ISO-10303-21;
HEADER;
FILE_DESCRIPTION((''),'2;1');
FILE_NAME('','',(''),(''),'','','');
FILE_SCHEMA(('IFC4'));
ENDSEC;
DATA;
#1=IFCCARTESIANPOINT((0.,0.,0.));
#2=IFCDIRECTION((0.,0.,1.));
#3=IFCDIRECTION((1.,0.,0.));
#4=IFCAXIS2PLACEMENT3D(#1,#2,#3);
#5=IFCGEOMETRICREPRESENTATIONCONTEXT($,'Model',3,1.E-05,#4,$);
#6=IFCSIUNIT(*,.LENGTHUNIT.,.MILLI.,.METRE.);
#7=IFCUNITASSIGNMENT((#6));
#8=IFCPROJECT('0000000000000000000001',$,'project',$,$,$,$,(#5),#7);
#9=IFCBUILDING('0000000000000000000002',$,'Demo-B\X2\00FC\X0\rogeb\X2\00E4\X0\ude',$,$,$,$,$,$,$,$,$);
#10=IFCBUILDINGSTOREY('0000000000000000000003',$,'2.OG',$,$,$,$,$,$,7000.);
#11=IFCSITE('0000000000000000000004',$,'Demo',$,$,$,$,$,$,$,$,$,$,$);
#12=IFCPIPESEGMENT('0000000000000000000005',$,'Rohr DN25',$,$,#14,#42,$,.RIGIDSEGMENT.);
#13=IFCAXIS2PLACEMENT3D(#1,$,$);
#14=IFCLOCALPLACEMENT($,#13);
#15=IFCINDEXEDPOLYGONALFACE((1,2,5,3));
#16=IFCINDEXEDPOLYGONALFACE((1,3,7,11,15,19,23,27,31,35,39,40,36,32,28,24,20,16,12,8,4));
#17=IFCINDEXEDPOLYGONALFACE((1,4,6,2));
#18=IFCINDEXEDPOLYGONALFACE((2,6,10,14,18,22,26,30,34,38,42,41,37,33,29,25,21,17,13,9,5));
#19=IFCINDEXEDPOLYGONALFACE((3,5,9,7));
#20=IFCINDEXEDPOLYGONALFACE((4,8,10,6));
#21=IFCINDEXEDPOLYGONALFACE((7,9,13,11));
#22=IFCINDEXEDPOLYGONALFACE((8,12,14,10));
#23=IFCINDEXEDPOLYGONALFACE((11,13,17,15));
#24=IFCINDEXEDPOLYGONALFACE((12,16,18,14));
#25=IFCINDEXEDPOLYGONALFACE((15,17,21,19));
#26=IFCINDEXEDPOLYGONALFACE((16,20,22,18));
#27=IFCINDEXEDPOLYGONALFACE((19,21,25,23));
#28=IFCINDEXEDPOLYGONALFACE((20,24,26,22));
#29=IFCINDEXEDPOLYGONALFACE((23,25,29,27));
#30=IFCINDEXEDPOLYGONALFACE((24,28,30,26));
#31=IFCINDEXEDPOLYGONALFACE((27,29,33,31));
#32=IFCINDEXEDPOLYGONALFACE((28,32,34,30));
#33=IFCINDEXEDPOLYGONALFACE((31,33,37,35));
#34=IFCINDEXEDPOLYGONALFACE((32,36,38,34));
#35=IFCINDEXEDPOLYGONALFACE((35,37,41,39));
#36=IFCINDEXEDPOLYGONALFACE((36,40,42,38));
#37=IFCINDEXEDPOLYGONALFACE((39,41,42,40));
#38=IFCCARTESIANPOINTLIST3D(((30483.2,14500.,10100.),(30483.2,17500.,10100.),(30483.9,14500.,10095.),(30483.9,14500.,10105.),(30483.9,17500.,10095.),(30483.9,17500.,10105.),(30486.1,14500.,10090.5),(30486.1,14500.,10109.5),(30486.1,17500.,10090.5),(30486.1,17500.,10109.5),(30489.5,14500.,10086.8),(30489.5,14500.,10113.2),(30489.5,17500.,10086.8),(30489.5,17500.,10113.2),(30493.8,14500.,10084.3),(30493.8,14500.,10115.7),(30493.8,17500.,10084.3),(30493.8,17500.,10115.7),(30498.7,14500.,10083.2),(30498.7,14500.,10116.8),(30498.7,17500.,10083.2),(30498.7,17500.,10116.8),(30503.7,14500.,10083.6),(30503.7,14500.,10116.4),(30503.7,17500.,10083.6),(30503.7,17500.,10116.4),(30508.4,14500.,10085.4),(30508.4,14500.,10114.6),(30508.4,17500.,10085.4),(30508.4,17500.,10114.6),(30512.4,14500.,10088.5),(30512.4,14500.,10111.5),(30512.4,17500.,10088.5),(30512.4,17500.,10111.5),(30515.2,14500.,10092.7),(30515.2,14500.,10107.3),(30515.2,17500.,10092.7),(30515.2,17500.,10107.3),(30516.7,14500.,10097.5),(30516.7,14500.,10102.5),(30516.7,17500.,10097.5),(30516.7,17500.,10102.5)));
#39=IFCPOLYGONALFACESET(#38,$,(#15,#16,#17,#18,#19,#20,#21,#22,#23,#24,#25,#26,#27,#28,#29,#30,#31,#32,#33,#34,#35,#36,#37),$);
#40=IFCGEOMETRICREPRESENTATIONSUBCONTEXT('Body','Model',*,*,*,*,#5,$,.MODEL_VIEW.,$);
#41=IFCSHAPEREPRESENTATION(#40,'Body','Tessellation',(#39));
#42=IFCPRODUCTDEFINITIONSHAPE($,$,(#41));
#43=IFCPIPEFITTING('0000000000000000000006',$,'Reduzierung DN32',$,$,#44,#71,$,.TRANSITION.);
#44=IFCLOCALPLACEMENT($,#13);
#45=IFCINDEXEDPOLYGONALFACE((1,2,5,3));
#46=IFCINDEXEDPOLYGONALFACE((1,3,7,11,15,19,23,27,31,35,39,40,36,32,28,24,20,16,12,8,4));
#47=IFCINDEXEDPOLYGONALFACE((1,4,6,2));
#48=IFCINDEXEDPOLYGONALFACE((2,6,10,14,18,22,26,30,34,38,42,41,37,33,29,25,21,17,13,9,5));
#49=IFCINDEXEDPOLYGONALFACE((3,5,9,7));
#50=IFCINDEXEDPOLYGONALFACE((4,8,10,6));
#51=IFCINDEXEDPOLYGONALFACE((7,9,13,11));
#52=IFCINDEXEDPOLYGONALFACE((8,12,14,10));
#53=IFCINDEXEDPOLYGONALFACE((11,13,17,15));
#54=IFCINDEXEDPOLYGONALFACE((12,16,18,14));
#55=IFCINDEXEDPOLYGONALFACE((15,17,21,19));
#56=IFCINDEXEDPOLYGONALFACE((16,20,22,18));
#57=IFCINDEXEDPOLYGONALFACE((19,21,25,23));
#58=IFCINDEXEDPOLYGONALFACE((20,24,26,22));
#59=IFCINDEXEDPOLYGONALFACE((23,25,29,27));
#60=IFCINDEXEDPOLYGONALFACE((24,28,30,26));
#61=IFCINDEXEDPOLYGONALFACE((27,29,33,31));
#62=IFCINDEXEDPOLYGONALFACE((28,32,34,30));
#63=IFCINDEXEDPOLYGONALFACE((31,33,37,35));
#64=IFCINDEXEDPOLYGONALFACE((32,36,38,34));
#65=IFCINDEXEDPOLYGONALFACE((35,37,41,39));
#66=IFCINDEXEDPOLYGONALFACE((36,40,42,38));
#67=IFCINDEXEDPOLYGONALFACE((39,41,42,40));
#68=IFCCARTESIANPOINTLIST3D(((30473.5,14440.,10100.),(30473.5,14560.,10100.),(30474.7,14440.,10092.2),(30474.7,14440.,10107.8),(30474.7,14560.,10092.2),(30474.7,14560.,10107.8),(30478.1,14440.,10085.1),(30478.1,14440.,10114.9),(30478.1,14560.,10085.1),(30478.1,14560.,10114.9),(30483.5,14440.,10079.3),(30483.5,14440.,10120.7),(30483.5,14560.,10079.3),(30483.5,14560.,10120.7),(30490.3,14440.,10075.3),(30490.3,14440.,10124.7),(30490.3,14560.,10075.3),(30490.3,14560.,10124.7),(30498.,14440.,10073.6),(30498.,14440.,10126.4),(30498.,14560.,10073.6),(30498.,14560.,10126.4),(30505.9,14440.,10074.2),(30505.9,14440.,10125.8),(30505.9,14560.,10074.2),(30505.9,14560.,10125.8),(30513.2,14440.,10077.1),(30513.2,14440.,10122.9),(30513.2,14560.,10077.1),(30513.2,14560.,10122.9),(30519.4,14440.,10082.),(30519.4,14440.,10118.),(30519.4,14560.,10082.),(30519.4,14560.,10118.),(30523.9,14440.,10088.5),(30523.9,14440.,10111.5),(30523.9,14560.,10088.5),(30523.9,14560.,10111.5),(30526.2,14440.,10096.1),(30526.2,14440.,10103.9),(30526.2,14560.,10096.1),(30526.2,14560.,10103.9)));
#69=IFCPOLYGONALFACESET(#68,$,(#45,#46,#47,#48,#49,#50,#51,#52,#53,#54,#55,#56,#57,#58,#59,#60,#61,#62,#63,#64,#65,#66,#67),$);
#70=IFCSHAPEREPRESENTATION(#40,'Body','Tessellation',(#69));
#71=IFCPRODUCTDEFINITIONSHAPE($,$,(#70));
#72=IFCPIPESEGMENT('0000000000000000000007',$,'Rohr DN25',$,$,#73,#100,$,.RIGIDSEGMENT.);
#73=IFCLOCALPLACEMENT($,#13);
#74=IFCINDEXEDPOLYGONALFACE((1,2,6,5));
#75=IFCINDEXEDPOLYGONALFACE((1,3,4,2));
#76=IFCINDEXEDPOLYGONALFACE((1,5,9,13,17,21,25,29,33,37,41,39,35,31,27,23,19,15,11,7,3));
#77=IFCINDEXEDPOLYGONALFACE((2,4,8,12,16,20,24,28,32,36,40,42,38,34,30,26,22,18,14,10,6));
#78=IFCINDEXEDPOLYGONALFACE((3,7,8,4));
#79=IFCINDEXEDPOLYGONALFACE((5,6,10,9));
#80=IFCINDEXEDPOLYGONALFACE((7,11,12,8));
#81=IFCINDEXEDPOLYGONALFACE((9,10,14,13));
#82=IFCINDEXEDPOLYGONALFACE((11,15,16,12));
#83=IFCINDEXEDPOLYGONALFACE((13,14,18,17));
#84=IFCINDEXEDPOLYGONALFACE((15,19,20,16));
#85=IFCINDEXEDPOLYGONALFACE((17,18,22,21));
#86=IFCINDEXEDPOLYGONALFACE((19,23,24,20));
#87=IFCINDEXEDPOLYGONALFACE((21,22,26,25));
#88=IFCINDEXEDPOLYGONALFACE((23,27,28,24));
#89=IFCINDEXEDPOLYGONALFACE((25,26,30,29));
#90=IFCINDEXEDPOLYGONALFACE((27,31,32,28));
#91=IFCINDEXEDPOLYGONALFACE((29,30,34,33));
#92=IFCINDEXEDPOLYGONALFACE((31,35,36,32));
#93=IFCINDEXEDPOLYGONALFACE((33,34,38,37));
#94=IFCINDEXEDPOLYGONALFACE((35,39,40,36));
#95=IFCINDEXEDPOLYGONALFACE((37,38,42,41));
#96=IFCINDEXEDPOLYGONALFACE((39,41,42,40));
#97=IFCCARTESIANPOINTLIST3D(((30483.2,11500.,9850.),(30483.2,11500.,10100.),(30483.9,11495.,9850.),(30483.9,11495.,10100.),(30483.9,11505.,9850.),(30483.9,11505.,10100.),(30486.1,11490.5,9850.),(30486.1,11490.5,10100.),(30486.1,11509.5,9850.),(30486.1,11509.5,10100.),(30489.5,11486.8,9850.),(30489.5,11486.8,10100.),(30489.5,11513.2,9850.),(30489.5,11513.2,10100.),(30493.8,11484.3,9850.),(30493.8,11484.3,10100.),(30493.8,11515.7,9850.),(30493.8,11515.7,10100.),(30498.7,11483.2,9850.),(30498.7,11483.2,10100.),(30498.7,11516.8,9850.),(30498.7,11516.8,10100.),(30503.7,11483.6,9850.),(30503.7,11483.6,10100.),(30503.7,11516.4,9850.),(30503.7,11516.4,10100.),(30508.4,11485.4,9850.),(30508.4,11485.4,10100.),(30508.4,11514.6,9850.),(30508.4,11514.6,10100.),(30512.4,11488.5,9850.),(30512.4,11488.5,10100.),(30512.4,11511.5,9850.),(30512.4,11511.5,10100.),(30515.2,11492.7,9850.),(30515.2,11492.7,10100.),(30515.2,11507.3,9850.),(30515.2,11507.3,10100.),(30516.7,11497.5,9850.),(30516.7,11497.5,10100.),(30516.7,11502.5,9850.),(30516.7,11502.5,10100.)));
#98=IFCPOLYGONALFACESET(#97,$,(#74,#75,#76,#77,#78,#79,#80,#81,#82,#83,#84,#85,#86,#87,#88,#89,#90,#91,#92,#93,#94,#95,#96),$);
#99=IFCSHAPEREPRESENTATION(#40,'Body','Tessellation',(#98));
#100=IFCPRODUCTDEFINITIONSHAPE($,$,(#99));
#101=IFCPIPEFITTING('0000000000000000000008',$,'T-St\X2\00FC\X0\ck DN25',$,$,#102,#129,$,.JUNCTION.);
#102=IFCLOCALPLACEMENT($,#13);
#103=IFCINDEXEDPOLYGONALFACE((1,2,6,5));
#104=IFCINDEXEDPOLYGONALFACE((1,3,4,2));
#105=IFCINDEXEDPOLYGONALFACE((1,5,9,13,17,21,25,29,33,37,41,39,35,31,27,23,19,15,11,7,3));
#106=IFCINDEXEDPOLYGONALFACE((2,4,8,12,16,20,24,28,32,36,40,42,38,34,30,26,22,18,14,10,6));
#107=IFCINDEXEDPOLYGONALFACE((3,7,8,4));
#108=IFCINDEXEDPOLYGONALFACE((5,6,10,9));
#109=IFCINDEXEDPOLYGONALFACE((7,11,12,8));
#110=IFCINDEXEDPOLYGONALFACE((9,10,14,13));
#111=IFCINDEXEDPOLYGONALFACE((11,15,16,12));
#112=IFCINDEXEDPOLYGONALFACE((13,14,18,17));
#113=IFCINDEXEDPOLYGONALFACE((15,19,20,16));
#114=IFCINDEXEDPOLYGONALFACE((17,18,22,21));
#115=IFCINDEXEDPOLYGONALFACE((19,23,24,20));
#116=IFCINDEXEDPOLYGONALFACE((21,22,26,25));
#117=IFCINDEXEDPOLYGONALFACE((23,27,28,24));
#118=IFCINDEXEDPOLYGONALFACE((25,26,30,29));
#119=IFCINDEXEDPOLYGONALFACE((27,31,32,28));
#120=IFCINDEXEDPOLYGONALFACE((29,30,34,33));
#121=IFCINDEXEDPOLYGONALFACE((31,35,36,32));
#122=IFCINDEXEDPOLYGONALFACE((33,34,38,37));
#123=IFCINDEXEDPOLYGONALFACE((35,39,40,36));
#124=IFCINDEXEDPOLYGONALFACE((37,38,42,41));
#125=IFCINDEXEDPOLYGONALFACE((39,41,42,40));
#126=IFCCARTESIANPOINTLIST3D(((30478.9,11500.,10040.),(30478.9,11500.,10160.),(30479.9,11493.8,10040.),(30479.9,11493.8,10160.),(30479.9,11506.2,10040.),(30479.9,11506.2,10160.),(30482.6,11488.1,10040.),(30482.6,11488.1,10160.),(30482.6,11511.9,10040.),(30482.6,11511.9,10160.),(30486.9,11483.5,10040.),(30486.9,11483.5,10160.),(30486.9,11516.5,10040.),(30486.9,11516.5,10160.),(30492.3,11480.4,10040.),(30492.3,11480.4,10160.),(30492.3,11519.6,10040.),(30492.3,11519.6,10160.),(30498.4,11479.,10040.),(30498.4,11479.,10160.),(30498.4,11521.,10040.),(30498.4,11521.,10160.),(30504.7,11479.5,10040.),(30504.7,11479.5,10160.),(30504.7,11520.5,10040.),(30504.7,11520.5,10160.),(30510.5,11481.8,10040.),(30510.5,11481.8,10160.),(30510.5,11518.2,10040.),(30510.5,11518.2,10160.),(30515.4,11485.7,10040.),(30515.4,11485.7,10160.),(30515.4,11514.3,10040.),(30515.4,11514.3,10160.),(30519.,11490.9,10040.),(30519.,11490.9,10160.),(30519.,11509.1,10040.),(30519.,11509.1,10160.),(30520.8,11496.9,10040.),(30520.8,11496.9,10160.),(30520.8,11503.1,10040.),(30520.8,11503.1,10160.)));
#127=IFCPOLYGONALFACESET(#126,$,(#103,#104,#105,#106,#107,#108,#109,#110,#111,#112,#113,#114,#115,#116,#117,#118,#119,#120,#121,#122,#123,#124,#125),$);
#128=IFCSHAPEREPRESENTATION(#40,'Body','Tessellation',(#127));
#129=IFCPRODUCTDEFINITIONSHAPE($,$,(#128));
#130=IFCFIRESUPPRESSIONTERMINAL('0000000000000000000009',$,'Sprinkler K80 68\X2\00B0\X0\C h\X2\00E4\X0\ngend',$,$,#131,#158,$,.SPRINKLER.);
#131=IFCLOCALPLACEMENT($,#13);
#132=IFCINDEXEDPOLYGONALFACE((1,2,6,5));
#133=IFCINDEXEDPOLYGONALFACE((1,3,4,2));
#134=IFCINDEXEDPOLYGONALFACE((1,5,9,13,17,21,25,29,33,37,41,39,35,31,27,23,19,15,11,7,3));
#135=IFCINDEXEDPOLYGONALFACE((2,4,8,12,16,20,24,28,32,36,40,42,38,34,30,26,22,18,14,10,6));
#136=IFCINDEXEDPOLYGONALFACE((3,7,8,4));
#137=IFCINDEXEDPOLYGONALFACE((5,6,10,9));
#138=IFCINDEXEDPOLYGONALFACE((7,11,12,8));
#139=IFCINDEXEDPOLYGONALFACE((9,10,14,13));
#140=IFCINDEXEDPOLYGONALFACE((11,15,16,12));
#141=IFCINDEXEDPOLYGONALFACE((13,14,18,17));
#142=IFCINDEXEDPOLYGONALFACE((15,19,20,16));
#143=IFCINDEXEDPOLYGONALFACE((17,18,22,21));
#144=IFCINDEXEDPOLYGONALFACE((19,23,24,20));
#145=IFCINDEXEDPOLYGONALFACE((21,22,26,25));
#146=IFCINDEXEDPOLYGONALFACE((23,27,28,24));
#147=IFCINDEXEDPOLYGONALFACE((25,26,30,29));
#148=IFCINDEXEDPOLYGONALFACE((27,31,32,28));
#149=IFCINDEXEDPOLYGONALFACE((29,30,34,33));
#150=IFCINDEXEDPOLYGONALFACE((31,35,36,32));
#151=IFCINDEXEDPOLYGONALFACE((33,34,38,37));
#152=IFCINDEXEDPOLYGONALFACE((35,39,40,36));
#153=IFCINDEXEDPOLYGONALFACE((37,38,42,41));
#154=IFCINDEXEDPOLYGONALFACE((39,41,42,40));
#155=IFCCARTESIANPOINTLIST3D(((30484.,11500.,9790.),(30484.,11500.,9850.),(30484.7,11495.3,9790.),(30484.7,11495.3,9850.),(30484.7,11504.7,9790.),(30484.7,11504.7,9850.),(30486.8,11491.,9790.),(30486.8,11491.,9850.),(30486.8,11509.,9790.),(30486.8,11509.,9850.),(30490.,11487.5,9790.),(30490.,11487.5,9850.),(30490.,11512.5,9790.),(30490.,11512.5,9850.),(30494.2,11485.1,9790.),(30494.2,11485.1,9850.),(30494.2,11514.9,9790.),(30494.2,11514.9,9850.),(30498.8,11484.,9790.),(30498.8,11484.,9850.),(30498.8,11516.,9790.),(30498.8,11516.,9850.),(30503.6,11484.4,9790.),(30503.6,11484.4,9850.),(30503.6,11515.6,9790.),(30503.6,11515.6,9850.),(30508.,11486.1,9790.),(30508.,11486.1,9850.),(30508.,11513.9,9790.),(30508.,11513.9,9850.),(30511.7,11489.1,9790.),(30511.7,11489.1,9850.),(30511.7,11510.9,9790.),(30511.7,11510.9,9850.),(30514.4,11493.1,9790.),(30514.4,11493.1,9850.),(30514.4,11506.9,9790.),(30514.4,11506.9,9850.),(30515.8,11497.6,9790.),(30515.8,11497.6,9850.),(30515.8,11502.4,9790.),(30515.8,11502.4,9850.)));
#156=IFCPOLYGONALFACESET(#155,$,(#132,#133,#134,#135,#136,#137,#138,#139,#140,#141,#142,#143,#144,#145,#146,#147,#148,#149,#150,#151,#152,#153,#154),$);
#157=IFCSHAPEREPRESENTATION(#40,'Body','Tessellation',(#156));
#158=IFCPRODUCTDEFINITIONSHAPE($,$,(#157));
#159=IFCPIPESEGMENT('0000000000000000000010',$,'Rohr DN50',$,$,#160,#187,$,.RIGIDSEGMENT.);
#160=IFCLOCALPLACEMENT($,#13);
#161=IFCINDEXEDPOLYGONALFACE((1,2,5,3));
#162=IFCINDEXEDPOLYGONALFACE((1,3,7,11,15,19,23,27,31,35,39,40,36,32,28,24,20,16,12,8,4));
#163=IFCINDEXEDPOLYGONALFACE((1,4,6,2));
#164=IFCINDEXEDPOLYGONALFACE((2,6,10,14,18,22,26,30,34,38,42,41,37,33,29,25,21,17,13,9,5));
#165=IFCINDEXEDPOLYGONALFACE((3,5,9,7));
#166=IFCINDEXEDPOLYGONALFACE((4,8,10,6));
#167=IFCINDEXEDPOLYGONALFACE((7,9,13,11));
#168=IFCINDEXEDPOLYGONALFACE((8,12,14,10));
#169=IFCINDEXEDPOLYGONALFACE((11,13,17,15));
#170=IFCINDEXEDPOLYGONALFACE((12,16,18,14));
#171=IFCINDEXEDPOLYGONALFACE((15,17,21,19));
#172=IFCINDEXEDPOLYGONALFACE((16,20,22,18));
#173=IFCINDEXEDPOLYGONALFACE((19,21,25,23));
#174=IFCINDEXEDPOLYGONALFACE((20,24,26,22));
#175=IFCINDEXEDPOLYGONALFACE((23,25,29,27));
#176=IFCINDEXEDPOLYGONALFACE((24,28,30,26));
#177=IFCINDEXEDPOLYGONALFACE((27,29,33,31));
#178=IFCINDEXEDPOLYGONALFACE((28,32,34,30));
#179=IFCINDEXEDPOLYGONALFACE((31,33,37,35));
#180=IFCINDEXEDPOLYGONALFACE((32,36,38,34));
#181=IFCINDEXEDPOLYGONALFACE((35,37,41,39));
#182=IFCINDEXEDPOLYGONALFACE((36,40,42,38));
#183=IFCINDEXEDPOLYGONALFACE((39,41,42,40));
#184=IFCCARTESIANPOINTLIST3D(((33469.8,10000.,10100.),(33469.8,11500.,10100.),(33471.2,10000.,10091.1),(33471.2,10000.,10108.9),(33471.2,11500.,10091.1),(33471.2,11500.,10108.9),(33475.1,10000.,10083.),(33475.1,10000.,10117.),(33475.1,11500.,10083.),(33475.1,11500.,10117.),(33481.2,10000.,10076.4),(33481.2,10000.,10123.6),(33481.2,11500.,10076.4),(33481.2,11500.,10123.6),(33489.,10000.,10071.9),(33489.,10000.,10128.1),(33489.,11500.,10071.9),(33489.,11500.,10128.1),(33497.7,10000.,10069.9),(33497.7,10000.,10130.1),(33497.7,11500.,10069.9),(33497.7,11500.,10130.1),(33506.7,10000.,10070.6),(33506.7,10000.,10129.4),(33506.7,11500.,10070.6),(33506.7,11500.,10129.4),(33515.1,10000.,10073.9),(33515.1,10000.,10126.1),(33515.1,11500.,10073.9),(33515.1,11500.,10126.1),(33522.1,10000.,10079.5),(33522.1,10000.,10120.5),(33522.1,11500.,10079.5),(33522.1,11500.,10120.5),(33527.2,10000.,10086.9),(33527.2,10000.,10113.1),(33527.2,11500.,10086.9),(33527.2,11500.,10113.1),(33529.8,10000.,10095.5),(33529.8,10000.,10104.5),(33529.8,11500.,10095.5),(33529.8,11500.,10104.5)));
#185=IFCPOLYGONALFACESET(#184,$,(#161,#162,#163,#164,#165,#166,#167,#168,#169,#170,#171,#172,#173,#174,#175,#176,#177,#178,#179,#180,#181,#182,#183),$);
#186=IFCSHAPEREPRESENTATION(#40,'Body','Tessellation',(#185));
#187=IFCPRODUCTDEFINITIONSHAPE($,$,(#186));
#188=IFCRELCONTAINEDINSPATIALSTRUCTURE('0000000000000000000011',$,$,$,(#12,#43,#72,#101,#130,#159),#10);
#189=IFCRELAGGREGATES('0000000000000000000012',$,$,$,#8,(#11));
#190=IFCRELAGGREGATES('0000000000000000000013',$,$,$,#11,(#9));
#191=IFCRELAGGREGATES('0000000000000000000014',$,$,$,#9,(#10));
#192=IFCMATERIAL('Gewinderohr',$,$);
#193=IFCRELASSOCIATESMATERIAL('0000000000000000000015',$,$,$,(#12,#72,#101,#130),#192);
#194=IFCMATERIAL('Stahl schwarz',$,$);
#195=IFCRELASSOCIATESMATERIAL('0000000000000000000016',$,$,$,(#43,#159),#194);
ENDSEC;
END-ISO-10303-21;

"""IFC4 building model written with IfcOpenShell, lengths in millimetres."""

from ifc_helpers import new_model, si_unit, frame, origin_with_axes, place, context, subcontext, project, spatial, circle, extrude, material, element, save


model = new_model("IFC4")

# Units and contexts
model_context = context("Model", 3, precision=1e-05, world=origin_with_axes())
body_context = subcontext(model_context, "Body", "Model", "MODEL_VIEW")
ifc_project = project(units=[si_unit("LENGTHUNIT", "METRE", prefix="MILLI")], contexts=[model_context])

# Site, building, storey
site = spatial("IfcSite", under=ifc_project, Name="Demo")
building = spatial("IfcBuilding", under=site, Name="Demo-Bürogebäude")
storey = spatial("IfcBuildingStorey", under=building, Name="2.OG", Elevation=7000.0)

# Pipe segment
ifc_material_1 = material(Name="Gewinderohr")
pipe_segment_1_placement = place(None, frame((30500.0, 14500.0, 10100.0), z_axis=(0.0, 1.0, 0.0), x_axis=(-1.0, 0.0, 0.0)))
element("IfcPipeSegment", 1, at=pipe_segment_1_placement, inside=storey, material=ifc_material_1, Name="Rohr DN25", PredefinedType="RIGIDSEGMENT", context=body_context, shape_type="SweptSolid", body=[
    extrude(circle(Radius=16.9), origin_with_axes(), (0.0, 0.0, 1.0), 3000.0),
])

# Pipe fitting
ifc_material_2 = material(Name="Stahl schwarz")
pipe_fitting_1_placement = place(None, frame((30500.0, 14440.0, 10100.0), z_axis=(0.0, 1.0, 0.0), x_axis=(-1.0, 0.0, 0.0)))
element("IfcPipeFitting", 2, at=pipe_fitting_1_placement, inside=storey, material=ifc_material_2, Name="Reduzierung DN32", PredefinedType="TRANSITION", context=body_context, shape_type="SweptSolid", body=[
    extrude(circle(Radius=26.5), origin_with_axes(), (0.0, 0.0, 1.0), 120.0),
])

# Pipe segment
pipe_segment_2_placement = place(None, frame((30500.0, 11500.0, 10100.0), z_axis=(0.0, 0.0, -1.0), x_axis=(-1.0, 0.0, 0.0)))
element("IfcPipeSegment", 3, at=pipe_segment_2_placement, inside=storey, material=ifc_material_1, Name="Rohr DN25", PredefinedType="RIGIDSEGMENT", context=body_context, shape_type="SweptSolid", body=[
    extrude(circle(Radius=16.9), origin_with_axes(), (0.0, 0.0, 1.0), 250.0),
])

# Pipe fitting
pipe_fitting_2_placement = place(None, frame((30500.0, 11500.0, 10160.0), z_axis=(0.0, 0.0, -1.0), x_axis=(-1.0, 0.0, 0.0)))
element("IfcPipeFitting", 4, at=pipe_fitting_2_placement, inside=storey, material=ifc_material_1, Name="T-Stück DN25", PredefinedType="JUNCTION", context=body_context, shape_type="SweptSolid", body=[
    extrude(circle(Radius=21.1), origin_with_axes(), (0.0, 0.0, 1.0), 120.0),
])

# Fire suppression terminal
fire_suppression_terminal_1_placement = place(None, frame((30500.0, 11500.0, 9850.0), z_axis=(0.0, 0.0, -1.0), x_axis=(-1.0, 0.0, 0.0)))
element("IfcFireSuppressionTerminal", 5, at=fire_suppression_terminal_1_placement, inside=storey, material=ifc_material_1, Name="Sprinkler K80 68°C hängend", PredefinedType="SPRINKLER", context=body_context, shape_type="SweptSolid", body=[
    extrude(circle(Radius=16.0), origin_with_axes(), (0.0, 0.0, 1.0), 60.0),
])

# Pipe segment
pipe_segment_3_placement = place(None, frame((33500.0, 10000.0, 10100.0), z_axis=(0.0, 1.0, 0.0), x_axis=(-1.0, 0.0, 0.0)))
element("IfcPipeSegment", 6, at=pipe_segment_3_placement, inside=storey, material=ifc_material_2, Name="Rohr DN50", PredefinedType="RIGIDSEGMENT", context=body_context, shape_type="SweptSolid", body=[
    extrude(circle(Radius=30.1), origin_with_axes(), (0.0, 0.0, 1.0), 1500.0),
])

save(model, "model.ifc")
